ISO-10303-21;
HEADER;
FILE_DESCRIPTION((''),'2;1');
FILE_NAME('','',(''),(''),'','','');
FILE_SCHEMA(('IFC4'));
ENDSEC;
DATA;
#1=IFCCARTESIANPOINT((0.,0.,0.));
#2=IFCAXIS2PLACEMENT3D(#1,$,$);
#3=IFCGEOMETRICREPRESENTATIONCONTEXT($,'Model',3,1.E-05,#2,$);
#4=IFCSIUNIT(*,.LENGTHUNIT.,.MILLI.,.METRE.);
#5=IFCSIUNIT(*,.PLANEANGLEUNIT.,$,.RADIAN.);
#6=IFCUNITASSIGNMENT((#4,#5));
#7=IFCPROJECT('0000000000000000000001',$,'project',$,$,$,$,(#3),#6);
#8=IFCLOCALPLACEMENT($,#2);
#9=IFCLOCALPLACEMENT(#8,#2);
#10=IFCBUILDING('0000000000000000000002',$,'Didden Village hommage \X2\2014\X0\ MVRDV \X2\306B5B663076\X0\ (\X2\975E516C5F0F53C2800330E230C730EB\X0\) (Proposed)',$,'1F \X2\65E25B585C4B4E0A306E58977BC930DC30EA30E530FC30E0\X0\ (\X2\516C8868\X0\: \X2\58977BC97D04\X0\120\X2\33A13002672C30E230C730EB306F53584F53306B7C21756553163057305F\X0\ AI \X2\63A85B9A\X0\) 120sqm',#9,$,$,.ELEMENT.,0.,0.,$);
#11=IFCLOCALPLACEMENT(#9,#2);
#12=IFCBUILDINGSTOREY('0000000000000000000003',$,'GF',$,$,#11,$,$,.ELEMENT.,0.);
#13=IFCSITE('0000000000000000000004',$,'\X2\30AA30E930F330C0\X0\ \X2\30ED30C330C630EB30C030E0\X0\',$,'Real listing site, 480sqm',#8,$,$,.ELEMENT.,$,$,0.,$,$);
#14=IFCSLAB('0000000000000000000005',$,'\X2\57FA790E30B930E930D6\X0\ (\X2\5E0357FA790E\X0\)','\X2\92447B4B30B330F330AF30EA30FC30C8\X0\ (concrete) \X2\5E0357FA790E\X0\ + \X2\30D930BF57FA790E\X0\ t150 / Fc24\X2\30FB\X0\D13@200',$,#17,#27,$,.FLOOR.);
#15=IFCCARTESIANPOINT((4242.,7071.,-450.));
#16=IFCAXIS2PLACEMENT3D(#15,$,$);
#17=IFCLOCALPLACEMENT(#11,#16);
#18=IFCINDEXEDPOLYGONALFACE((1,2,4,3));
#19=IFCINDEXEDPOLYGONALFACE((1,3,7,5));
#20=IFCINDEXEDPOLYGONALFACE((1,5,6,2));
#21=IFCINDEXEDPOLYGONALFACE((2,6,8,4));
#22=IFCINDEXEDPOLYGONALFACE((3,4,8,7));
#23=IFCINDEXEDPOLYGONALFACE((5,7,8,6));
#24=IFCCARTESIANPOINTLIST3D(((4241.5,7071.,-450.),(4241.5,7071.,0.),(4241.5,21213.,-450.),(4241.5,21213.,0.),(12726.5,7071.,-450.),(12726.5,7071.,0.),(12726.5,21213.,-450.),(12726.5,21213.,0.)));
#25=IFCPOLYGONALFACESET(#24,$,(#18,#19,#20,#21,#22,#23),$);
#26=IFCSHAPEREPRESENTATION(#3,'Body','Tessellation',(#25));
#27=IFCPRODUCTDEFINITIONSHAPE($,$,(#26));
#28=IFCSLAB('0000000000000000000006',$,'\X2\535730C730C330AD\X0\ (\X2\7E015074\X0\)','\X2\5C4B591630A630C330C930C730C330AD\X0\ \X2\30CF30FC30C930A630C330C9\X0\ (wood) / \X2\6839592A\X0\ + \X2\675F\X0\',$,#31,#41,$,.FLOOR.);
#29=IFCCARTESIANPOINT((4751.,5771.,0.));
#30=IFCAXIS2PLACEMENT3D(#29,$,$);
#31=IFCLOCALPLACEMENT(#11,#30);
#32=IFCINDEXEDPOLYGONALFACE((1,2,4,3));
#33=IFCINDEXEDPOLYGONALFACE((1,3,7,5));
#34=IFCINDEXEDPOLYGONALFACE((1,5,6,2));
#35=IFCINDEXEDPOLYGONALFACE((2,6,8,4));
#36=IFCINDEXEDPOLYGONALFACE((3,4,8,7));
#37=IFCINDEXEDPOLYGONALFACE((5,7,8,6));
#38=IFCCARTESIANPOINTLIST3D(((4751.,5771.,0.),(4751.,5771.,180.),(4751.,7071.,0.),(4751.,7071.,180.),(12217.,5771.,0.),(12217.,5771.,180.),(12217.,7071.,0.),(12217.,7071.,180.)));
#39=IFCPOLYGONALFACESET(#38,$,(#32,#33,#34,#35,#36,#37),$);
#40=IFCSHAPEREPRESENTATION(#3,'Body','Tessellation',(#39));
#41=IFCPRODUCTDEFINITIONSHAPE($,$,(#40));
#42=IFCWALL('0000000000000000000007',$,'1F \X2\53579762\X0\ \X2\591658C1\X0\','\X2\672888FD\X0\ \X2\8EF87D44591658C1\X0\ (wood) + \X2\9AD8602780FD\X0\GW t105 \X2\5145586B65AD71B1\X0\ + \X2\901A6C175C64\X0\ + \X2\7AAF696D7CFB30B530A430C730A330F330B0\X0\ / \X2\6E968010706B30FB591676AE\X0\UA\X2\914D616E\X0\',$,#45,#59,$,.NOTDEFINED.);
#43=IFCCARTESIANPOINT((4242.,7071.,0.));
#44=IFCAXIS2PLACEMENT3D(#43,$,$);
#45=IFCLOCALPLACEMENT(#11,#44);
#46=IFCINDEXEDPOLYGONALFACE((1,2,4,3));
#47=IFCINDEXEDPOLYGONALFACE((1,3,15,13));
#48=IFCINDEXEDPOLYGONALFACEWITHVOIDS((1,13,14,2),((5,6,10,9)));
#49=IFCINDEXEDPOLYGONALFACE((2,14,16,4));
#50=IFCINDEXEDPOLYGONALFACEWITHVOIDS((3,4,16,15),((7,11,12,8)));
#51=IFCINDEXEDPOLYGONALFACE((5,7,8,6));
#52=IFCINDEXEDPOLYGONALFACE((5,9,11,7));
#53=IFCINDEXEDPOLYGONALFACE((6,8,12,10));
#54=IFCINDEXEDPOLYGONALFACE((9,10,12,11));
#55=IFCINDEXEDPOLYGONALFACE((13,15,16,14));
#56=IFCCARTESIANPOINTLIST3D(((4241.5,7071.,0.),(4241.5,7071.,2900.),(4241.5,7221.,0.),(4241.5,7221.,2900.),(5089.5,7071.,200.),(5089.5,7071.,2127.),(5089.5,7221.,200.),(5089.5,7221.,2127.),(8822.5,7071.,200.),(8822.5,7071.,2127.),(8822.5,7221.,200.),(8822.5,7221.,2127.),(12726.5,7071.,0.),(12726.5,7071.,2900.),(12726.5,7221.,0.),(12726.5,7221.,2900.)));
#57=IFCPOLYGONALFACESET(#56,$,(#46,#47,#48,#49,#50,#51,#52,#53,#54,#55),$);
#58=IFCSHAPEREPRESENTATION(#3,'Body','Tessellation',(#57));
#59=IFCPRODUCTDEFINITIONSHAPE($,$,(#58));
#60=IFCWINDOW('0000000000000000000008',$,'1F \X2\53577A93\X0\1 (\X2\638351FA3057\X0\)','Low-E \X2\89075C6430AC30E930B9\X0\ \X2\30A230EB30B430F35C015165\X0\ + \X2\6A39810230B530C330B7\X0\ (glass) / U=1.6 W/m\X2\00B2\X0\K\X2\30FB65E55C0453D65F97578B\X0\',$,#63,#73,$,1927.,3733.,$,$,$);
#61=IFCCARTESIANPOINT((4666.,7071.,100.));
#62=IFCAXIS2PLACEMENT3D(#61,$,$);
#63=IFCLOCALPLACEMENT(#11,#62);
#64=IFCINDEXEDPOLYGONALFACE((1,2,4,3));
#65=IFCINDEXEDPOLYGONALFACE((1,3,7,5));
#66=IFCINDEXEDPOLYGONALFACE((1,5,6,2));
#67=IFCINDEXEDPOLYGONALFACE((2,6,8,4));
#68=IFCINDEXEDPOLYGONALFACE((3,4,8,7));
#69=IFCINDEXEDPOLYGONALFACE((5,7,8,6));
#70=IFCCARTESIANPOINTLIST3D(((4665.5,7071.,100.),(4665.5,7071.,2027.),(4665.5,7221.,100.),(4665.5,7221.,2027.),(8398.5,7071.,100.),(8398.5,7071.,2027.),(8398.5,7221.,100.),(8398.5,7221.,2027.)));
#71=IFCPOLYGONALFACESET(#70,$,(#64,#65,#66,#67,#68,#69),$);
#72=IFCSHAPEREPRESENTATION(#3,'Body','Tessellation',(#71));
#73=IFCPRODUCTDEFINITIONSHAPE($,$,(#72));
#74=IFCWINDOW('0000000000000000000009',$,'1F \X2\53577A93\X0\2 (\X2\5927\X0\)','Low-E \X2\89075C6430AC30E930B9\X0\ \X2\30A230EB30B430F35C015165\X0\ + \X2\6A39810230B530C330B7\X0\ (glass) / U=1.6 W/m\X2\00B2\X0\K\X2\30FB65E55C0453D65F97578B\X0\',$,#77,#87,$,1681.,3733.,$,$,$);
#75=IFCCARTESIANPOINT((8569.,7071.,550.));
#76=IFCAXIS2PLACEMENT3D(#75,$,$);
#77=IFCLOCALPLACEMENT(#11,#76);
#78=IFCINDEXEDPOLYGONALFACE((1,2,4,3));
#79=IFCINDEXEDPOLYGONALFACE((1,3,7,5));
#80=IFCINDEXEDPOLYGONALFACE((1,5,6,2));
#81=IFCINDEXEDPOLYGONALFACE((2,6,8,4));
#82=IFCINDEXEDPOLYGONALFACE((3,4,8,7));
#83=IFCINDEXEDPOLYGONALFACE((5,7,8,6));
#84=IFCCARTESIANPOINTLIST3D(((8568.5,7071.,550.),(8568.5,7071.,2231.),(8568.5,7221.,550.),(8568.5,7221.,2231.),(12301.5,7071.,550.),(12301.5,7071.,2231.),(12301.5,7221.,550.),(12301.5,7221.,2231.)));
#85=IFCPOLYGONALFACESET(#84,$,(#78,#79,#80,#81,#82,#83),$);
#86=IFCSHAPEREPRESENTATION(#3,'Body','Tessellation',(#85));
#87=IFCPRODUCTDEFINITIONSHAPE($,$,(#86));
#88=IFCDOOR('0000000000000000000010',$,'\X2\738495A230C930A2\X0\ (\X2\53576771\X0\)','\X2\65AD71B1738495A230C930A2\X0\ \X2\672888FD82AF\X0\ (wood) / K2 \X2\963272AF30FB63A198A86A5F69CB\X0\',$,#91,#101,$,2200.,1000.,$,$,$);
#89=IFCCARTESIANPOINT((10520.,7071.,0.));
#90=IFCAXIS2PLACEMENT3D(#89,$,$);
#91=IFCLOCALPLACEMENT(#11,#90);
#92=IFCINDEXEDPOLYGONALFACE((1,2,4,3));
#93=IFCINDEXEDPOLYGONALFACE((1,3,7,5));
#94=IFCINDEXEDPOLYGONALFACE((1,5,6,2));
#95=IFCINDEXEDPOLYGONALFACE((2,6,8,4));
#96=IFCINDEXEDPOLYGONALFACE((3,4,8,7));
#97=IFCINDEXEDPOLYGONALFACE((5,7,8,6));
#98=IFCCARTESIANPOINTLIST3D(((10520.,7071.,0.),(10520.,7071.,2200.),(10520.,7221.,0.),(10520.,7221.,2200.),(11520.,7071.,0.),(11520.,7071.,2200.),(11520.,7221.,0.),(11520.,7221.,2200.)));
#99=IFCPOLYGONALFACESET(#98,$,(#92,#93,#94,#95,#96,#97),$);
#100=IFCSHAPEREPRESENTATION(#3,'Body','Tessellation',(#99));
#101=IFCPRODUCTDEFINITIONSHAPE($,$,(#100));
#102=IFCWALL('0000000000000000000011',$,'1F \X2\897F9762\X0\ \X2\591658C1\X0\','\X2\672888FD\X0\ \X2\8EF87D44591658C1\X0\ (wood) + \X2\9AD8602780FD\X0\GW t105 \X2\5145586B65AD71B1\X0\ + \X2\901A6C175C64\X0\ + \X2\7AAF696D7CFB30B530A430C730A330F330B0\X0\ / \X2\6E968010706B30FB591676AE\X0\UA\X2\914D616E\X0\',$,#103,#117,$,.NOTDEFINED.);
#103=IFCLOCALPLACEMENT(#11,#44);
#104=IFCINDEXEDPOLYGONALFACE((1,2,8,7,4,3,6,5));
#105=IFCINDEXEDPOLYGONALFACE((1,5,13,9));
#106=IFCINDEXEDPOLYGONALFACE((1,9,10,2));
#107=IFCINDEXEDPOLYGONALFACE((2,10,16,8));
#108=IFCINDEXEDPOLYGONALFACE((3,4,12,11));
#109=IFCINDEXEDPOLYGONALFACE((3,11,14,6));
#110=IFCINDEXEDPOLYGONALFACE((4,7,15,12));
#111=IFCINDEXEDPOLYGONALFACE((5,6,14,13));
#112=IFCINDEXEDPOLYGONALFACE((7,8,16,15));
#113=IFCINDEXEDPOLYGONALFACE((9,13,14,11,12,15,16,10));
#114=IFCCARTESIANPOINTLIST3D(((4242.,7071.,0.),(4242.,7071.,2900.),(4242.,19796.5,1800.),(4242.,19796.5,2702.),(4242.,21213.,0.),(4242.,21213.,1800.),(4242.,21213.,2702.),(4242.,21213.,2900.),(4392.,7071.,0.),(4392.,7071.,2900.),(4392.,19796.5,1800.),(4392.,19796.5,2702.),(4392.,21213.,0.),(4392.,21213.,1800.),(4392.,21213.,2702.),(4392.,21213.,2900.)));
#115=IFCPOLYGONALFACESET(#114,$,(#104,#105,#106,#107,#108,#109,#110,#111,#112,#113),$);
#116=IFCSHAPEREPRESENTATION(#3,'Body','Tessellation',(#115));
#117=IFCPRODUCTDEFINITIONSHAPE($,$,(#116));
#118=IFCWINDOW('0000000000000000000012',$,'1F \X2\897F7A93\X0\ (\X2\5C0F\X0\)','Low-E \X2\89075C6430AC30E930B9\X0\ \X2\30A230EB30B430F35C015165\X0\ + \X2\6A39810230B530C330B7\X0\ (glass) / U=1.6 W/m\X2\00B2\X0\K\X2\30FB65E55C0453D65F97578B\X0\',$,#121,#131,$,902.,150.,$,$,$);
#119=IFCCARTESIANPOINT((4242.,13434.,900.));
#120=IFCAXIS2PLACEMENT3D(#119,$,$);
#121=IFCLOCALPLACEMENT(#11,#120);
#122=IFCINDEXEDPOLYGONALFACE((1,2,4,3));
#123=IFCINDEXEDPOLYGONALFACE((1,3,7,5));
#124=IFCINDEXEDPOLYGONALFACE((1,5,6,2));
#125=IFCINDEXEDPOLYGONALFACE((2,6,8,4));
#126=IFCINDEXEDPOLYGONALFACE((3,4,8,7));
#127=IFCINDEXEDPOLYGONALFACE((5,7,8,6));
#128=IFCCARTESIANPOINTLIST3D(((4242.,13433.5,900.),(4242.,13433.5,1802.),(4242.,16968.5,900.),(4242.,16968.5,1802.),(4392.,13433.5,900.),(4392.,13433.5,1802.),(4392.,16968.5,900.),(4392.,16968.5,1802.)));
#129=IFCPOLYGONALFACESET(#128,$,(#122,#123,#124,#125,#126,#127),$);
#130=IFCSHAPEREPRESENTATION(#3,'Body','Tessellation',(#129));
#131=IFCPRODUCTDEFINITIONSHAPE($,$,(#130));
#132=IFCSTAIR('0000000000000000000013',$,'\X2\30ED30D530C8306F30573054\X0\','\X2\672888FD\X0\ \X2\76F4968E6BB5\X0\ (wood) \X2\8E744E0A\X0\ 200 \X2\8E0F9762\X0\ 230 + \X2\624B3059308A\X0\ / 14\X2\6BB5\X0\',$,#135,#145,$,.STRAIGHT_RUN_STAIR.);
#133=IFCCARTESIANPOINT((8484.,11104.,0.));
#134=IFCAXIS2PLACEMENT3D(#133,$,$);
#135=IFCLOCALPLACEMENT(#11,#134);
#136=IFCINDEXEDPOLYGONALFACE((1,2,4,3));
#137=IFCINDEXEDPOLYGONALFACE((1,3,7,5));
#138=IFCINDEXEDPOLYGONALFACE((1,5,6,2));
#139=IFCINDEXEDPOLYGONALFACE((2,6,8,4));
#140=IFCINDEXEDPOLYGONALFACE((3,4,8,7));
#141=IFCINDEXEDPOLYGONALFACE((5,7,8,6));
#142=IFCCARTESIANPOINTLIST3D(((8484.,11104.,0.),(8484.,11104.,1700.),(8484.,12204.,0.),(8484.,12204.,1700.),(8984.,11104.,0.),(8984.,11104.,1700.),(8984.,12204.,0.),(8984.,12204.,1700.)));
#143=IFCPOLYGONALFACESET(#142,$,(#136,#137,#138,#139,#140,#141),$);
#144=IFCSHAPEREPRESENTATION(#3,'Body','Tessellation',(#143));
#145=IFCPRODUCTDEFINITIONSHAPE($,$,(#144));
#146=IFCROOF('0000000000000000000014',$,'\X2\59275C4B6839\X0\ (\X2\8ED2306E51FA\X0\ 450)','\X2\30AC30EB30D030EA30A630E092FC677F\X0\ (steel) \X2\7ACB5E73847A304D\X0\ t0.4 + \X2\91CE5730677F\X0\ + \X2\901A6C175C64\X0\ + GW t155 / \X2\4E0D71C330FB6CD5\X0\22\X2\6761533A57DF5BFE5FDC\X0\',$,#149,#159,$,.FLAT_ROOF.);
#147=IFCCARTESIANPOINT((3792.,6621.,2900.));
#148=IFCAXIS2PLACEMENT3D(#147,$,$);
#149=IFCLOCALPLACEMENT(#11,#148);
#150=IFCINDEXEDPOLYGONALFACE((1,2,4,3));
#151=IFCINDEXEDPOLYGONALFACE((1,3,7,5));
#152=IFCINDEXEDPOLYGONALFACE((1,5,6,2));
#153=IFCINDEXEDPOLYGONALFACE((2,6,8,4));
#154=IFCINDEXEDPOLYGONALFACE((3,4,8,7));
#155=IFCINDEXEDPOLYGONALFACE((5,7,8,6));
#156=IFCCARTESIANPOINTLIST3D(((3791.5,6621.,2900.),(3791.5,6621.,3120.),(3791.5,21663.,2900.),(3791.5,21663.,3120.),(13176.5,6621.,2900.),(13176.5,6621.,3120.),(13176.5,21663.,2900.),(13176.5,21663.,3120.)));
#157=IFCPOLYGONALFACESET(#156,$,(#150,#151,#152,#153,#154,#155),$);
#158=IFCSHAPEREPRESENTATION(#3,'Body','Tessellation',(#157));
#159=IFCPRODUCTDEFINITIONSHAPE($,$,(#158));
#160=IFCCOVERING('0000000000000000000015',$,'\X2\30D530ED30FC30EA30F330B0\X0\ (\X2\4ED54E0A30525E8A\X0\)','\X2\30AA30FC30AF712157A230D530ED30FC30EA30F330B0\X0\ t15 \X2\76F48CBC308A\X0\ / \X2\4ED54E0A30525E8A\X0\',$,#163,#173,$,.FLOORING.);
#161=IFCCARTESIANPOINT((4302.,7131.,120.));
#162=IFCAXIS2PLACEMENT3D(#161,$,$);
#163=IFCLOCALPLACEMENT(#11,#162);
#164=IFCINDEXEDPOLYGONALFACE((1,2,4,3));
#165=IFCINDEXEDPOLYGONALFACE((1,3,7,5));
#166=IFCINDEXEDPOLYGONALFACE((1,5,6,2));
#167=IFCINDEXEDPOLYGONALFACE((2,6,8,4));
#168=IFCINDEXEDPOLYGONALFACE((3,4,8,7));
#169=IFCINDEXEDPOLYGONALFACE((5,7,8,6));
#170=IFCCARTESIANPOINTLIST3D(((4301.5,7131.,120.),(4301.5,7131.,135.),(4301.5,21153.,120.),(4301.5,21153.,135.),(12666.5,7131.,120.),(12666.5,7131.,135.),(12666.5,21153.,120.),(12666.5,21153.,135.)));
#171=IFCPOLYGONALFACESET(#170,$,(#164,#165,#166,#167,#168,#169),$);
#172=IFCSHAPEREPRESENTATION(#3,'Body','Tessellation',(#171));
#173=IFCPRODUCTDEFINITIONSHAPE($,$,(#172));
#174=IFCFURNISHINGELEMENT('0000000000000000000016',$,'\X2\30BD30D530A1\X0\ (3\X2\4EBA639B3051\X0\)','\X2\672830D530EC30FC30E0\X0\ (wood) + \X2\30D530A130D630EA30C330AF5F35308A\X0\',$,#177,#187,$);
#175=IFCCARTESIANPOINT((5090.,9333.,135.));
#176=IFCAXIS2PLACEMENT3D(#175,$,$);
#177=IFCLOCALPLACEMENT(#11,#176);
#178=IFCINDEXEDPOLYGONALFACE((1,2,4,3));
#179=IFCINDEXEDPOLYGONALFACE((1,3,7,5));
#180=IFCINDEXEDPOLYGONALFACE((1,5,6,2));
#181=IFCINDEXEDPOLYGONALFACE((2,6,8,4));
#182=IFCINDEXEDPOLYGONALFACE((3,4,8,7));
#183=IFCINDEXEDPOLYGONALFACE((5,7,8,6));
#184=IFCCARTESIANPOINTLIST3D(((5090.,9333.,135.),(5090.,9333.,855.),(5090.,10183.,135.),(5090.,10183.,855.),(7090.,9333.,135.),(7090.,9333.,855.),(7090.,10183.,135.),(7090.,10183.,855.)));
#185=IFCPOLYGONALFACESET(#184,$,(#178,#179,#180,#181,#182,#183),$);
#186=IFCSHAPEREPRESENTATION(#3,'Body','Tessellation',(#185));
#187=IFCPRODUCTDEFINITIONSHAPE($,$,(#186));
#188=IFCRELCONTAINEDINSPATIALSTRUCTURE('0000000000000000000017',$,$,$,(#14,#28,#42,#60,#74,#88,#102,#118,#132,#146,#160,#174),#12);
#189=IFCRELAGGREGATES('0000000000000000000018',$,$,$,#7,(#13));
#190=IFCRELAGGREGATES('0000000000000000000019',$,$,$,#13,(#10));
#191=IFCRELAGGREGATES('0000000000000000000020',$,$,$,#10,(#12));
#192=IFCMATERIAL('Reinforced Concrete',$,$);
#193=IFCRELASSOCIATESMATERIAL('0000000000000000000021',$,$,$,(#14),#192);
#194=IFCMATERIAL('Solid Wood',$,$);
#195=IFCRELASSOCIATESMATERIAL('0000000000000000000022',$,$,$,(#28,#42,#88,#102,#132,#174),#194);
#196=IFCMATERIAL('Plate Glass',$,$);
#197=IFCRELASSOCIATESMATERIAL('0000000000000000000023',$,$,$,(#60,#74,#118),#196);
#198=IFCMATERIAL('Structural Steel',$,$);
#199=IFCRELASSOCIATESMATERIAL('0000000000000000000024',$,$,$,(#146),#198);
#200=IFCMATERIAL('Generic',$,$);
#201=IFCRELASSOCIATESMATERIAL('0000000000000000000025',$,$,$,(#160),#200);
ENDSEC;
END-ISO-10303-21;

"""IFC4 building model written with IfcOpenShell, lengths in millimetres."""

from ifc_helpers import new_model, si_unit, frame, frame_2d, origin, place, context, project, spatial, rectangle, extrude, material, element, fill, save


model = new_model("IFC4")

# Units and contexts
model_context = context("Model", 3, precision=1e-05, world=origin())
ifc_project = project(units=[si_unit("LENGTHUNIT", "METRE", prefix="MILLI"), si_unit("PLANEANGLEUNIT", "RADIAN")], contexts=[model_context])

# Site, building, storey
site_placement = place(None, origin())
site = spatial("IfcSite", under=ifc_project, at=site_placement, Name="オランダ ロッテルダム", ObjectType="Real listing site, 480sqm", CompositionType="ELEMENT", RefElevation=0.0)
building_placement = place(site_placement, origin())
building = spatial("IfcBuilding", under=site, at=building_placement, Name="Didden Village hommage — MVRDV に学ぶ (非公式参考モデル) (Proposed)", ObjectType="1F 既存屋上の増築ボリューム (公表: 増築約120㎡。本モデルは単体に簡略化した AI 推定) 120sqm", CompositionType="ELEMENT", ElevationOfRefHeight=0.0, ElevationOfTerrain=0.0)
storey_placement = place(building_placement, origin())
storey = spatial("IfcBuildingStorey", under=building, at=storey_placement, Name="GF", CompositionType="ELEMENT", Elevation=0.0)

# Slabs
ifc_material_1 = material(Name="Reinforced Concrete")
slab_1_placement = place(storey_placement, frame((4242.0, 7071.0, -450.0)))
element("IfcSlab", 1, at=slab_1_placement, inside=storey, material=ifc_material_1, Name="基礎スラブ (布基礎)", Description="鉄筋コンクリート (concrete) 布基礎 + ベタ基礎 t150 / Fc24・D13@200", PredefinedType="FLOOR", context=model_context, shape_type="SweptSolid", body=[
    extrude(rectangle(XDim=8485.0, YDim=14142.0, at=frame_2d((4242.0, 7071.0))), frame((4242.0, 7071.0, -450.0)), (0.0, 0.0, 1.0), 450.0),
])
ifc_material_2 = material(Name="Solid Wood")
slab_2_placement = place(storey_placement, frame((4751.0, 5771.0, 0.0)))
element("IfcSlab", 2, at=slab_2_placement, inside=storey, material=ifc_material_2, Name="南デッキ (縁側)", Description="屋外ウッドデッキ ハードウッド (wood) / 根太 + 束", PredefinedType="FLOOR", context=model_context, shape_type="SweptSolid", body=[
    extrude(rectangle(XDim=7466.0, YDim=1300.0, at=frame_2d((3733.0, 650.0))), frame((4751.0, 5771.0, 0.0)), (0.0, 0.0, 1.0), 180.0),
])

# Wall, openings, windows, door
wall_1_placement = place(storey_placement, frame((4242.0, 7071.0, 0.0)))
wall_1 = element("IfcWall", 3, at=wall_1_placement, inside=storey, material=ifc_material_2, Name="1F 南面 外壁", Description="木製 軸組外壁 (wood) + 高性能GW t105 充填断熱 + 通気層 + 窯業系サイディング / 準耐火・外皮UA配慮", PredefinedType="NOTDEFINED", context=model_context, shape_type="SweptSolid", body=[
    extrude(rectangle(XDim=8485.0, YDim=150.0, at=frame_2d((4242.0, 75.0))), frame((4242.0, 7071.0, 0.0)), (0.0, 0.0, 1.0), 2900.0),
])
opening_1_placement = place(storey_placement, frame((4666.0, 7071.0, 100.0)))
opening_1 = element("IfcOpeningElement", 4, at=opening_1_placement, cuts=wall_1, PredefinedType="NOTDEFINED", context=model_context, shape_type="SweptSolid", body=[
    extrude(rectangle(XDim=3733.0, YDim=150.0, at=frame_2d((1866.0, 75.0))), frame((4666.0, 7071.0, 100.0)), (0.0, 0.0, 1.0), 1927.0),
])
opening_2_placement = place(storey_placement, frame((8569.0, 7071.0, 550.0)))
opening_2 = element("IfcOpeningElement", 5, at=opening_2_placement, cuts=wall_1, PredefinedType="NOTDEFINED", context=model_context, shape_type="SweptSolid", body=[
    extrude(rectangle(XDim=3733.0, YDim=150.0, at=frame_2d((1866.0, 75.0))), frame((8569.0, 7071.0, 550.0)), (0.0, 0.0, 1.0), 1681.0),
])
opening_3_placement = place(storey_placement, frame((10520.0, 7071.0, 0.0)))
opening_3 = element("IfcOpeningElement", 6, at=opening_3_placement, cuts=wall_1, PredefinedType="NOTDEFINED", context=model_context, shape_type="SweptSolid", body=[
    extrude(rectangle(XDim=1000.0, YDim=150.0, at=frame_2d((500.0, 75.0))), frame((10520.0, 7071.0, 0.0)), (0.0, 0.0, 1.0), 2200.0),
])
ifc_material_3 = material(Name="Plate Glass")
window_1_placement = place(storey_placement, frame((4666.0, 7071.0, 100.0)))
window_1 = element("IfcWindow", 7, at=window_1_placement, inside=storey, material=ifc_material_3, Name="1F 南窓1 (掃出し)", Description="Low-E 複層ガラス アルゴン封入 + 樹脂サッシ (glass) / U=1.6 W/m²K・日射取得型", OverallHeight=1927.0, OverallWidth=3733.0, context=model_context, shape_type="SweptSolid", body=[
    extrude(rectangle(XDim=3733.0, YDim=150.0, at=frame_2d((1866.0, 75.0))), frame((4666.0, 7071.0, 100.0)), (0.0, 0.0, 1.0), 1927.0),
])
fill(opening_1, window_1)
window_2_placement = place(storey_placement, frame((8569.0, 7071.0, 550.0)))
window_2 = element("IfcWindow", 8, at=window_2_placement, inside=storey, material=ifc_material_3, Name="1F 南窓2 (大)", Description="Low-E 複層ガラス アルゴン封入 + 樹脂サッシ (glass) / U=1.6 W/m²K・日射取得型", OverallHeight=1681.0, OverallWidth=3733.0, context=model_context, shape_type="SweptSolid", body=[
    extrude(rectangle(XDim=3733.0, YDim=150.0, at=frame_2d((1866.0, 75.0))), frame((8569.0, 7071.0, 550.0)), (0.0, 0.0, 1.0), 1681.0),
])
fill(opening_2, window_2)
door_placement = place(storey_placement, frame((10520.0, 7071.0, 0.0)))
door = element("IfcDoor", 9, at=door_placement, inside=storey, material=ifc_material_2, Name="玄関ドア (南東)", Description="断熱玄関ドア 木製芯 (wood) / K2 防犯・採風機構", OverallHeight=2200.0, OverallWidth=1000.0, context=model_context, shape_type="SweptSolid", body=[
    extrude(rectangle(XDim=1000.0, YDim=150.0, at=frame_2d((500.0, 75.0))), frame((10520.0, 7071.0, 0.0)), (0.0, 0.0, 1.0), 2200.0),
])
fill(opening_3, door)

# Wall, opening, window
wall_2_placement = place(storey_placement, frame((4242.0, 7071.0, 0.0)))
wall_2 = element("IfcWall", 10, at=wall_2_placement, inside=storey, material=ifc_material_2, Name="1F 西面 外壁", Description="木製 軸組外壁 (wood) + 高性能GW t105 充填断熱 + 通気層 + 窯業系サイディング / 準耐火・外皮UA配慮", PredefinedType="NOTDEFINED", context=model_context, shape_type="SweptSolid", body=[
    extrude(rectangle(XDim=150.0, YDim=14142.0, at=frame_2d((75.0, 7071.0))), frame((4242.0, 7071.0, 0.0)), (0.0, 0.0, 1.0), 2900.0),
])
opening_4_placement = place(storey_placement, frame((4242.0, 13434.0, 900.0)))
opening_4 = element("IfcOpeningElement", 11, at=opening_4_placement, cuts=wall_2, PredefinedType="NOTDEFINED", context=model_context, shape_type="SweptSolid", body=[
    extrude(rectangle(XDim=150.0, YDim=3535.0, at=frame_2d((75.0, 1767.0))), frame((4242.0, 13434.0, 900.0)), (0.0, 0.0, 1.0), 902.0),
])
window_3_placement = place(storey_placement, frame((4242.0, 13434.0, 900.0)))
window_3 = element("IfcWindow", 12, at=window_3_placement, inside=storey, material=ifc_material_3, Name="1F 西窓 (小)", Description="Low-E 複層ガラス アルゴン封入 + 樹脂サッシ (glass) / U=1.6 W/m²K・日射取得型", OverallHeight=902.0, OverallWidth=150.0, context=model_context, shape_type="SweptSolid", body=[
    extrude(rectangle(XDim=150.0, YDim=3535.0, at=frame_2d((75.0, 1767.0))), frame((4242.0, 13434.0, 900.0)), (0.0, 0.0, 1.0), 902.0),
])
fill(opening_4, window_3)

# Stair
stair_placement = place(storey_placement, frame((8484.0, 11104.0, 0.0)))
element("IfcStair", 13, at=stair_placement, inside=storey, material=ifc_material_2, Name="ロフトはしご", Description="木製 直階段 (wood) 蹴上 200 踏面 230 + 手すり / 14段", PredefinedType="STRAIGHT_RUN_STAIR", context=model_context, shape_type="SweptSolid", body=[
    extrude(rectangle(XDim=500.0, YDim=1100.0, at=frame_2d((250.0, 550.0))), frame((8484.0, 11104.0, 0.0)), (0.0, 0.0, 1.0), 1700.0),
])

# Roof
ifc_material_4 = material(Name="Structural Steel")
roof_placement = place(storey_placement, frame((3792.0, 6621.0, 2900.0)))
element("IfcRoof", 14, at=roof_placement, inside=storey, material=ifc_material_4, Name="大屋根 (軒の出 450)", Description="ガルバリウム鋼板 (steel) 立平葺き t0.4 + 野地板 + 通気層 + GW t155 / 不燃・法22条区域対応", PredefinedType="FLAT_ROOF", context=model_context, shape_type="SweptSolid", body=[
    extrude(rectangle(XDim=9385.0, YDim=15042.0, at=frame_2d((4692.0, 7521.0))), frame((3792.0, 6621.0, 2900.0)), (0.0, 0.0, 1.0), 220.0),
])

# Covering
ifc_material_5 = material(Name="Generic")
covering_placement = place(storey_placement, frame((4302.0, 7131.0, 120.0)))
element("IfcCovering", 15, at=covering_placement, inside=storey, material=ifc_material_5, Name="フローリング (仕上げ床)", Description="オーク無垢フローリング t15 直貼り / 仕上げ床", PredefinedType="FLOORING", context=model_context, shape_type="SweptSolid", body=[
    extrude(rectangle(XDim=8365.0, YDim=14022.0, at=frame_2d((4182.0, 7011.0))), frame((4302.0, 7131.0, 120.0)), (0.0, 0.0, 1.0), 15.0),
])

# Furnishing element
furnishing_1_placement = place(storey_placement, frame((5090.0, 9333.0, 135.0)))
element("IfcFurnishingElement", 16, at=furnishing_1_placement, inside=storey, material=ifc_material_2, Name="ソファ (3人掛け)", Description="木フレーム (wood) + ファブリック張り", context=model_context, shape_type="SweptSolid", body=[
    extrude(rectangle(XDim=2000.0, YDim=850.0, at=frame_2d((1000.0, 425.0))), frame((5090.0, 9333.0, 135.0)), (0.0, 0.0, 1.0), 720.0),
])

save(model, "model.ifc")
